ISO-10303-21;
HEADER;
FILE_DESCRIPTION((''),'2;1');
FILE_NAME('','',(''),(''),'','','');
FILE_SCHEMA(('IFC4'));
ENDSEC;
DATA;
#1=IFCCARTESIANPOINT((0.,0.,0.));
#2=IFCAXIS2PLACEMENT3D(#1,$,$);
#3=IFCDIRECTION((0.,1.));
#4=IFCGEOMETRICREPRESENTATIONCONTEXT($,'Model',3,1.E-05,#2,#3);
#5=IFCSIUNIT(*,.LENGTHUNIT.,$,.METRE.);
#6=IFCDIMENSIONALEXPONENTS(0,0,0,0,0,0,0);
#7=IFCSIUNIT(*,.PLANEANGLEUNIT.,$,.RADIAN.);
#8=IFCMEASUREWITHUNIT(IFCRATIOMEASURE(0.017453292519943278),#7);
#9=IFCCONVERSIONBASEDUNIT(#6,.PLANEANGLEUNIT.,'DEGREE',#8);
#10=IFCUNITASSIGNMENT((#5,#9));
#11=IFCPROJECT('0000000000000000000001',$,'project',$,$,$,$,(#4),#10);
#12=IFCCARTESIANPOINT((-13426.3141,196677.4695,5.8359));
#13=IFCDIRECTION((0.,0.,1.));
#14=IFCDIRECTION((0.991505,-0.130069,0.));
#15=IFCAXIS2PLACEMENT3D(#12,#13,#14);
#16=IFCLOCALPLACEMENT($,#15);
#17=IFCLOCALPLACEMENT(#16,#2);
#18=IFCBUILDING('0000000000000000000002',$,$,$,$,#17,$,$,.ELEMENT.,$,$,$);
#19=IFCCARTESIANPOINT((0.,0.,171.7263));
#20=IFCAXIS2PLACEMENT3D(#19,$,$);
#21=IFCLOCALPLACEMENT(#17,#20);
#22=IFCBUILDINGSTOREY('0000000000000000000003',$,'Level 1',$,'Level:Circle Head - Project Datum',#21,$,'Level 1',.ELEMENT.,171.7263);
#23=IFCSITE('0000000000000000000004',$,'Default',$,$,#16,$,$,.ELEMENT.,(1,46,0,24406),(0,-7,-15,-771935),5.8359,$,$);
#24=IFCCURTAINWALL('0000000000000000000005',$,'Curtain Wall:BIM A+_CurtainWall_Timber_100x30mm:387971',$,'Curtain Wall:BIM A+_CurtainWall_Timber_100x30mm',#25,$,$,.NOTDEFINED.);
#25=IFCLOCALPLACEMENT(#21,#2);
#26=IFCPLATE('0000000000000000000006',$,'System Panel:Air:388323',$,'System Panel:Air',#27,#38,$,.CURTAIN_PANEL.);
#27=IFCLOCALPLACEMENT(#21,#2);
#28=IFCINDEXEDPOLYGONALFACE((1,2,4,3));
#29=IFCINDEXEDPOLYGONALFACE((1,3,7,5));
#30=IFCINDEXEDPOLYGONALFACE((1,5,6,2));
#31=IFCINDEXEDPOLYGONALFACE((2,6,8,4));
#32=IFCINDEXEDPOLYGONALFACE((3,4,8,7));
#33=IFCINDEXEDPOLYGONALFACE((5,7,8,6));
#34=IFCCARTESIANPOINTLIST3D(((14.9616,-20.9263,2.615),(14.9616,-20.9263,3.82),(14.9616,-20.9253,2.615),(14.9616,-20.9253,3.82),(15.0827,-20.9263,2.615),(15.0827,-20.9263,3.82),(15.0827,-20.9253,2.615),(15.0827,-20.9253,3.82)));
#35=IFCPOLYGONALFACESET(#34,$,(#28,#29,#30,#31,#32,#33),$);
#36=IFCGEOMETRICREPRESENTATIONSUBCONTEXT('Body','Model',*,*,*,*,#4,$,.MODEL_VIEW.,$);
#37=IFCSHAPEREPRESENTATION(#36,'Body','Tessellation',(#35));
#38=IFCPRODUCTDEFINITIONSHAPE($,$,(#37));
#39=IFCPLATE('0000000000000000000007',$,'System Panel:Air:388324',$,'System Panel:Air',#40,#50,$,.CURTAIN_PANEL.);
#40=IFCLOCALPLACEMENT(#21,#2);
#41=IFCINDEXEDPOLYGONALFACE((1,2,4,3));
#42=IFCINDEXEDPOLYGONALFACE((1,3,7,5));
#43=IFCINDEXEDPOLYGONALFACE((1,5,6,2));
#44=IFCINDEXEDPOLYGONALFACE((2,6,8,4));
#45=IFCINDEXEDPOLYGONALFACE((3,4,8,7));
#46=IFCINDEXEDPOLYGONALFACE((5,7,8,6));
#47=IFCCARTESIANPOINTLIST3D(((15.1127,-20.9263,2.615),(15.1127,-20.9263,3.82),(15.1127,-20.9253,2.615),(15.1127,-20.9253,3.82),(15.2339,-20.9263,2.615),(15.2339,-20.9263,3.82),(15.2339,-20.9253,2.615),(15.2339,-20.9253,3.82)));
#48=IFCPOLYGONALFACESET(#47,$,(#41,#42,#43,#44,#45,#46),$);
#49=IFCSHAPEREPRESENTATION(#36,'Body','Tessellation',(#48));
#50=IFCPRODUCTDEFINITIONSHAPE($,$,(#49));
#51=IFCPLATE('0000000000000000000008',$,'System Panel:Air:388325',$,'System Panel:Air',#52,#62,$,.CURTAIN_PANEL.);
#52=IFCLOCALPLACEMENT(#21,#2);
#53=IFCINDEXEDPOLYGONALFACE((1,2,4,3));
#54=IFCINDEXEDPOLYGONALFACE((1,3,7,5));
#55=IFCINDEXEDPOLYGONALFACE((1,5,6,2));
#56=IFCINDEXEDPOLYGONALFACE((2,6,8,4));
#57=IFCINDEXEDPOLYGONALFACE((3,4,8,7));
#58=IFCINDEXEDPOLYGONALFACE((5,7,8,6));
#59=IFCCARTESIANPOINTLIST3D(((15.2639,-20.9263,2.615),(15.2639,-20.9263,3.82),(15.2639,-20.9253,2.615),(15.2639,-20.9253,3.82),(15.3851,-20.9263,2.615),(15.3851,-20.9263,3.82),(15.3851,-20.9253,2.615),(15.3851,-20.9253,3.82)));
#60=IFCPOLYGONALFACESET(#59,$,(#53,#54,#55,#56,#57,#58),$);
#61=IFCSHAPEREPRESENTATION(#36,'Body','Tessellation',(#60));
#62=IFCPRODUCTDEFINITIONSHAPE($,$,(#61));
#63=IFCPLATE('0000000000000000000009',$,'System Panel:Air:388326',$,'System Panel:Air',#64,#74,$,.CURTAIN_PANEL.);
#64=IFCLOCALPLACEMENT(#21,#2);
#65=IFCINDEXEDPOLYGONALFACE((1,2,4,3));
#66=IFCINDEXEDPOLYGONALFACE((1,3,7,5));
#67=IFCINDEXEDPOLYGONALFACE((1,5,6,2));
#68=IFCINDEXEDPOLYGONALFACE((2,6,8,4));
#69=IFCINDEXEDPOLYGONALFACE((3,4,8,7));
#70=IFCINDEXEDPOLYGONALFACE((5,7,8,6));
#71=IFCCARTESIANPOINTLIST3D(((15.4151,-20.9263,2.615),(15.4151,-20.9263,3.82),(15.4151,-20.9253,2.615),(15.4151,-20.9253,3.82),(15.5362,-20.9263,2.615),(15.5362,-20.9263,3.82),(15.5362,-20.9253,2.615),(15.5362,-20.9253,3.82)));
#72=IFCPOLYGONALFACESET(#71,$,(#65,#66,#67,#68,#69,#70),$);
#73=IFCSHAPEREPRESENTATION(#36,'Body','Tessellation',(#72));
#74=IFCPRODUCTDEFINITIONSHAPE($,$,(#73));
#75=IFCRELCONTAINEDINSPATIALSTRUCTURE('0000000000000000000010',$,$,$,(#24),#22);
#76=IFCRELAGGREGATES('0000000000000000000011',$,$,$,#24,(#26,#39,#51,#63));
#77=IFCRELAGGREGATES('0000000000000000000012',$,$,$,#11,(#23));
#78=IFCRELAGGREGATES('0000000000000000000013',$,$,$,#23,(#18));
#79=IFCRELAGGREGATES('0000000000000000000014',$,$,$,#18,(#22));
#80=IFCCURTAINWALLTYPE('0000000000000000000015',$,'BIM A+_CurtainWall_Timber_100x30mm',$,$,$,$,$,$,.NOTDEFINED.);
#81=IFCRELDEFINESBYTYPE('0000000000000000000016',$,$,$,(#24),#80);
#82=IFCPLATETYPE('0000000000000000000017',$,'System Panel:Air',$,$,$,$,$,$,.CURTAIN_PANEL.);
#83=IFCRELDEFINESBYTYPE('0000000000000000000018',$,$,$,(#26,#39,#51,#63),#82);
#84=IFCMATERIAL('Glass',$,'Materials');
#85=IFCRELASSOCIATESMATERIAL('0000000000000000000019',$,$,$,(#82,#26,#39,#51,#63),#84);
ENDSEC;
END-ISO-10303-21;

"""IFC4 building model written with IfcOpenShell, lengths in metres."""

from ifc_helpers import new_model, entity, si_unit, converted_unit, direction, frame, origin, place, context, subcontext, project, spatial, indexed_curve, outline, extrude, source, transform, mapped, material, type_object, type_shapes, element, aggregate, save


model = new_model("IFC4")

# Units and contexts
model_context = context("Model", 3, precision=1e-05, world=origin(), true_north=direction((0.0, 1.0)))
body_context = subcontext(model_context, "Body", "Model", "MODEL_VIEW")
ifc_project = project(units=[si_unit("LENGTHUNIT", "METRE"), converted_unit("PLANEANGLEUNIT", "DEGREE", entity("IfcRatioMeasure", 0.017453292519943278), si_unit("PLANEANGLEUNIT", "RADIAN"), dimensions=[0, 0, 0, 0, 0, 0, 0])], contexts=[model_context])

# Site, building, storey
site_placement = place(None, frame((-13426.3141, 196677.4695, 5.8359), z_axis=(0.0, 0.0, 1.0), x_axis=(0.991505, -0.130069, 0.0)))
site = spatial("IfcSite", under=ifc_project, at=site_placement, Name="Default", CompositionType="ELEMENT", RefLatitude=(1, 46, 0, 24406), RefLongitude=(0, -7, -15, -771935), RefElevation=5.8359)
building_placement = place(site_placement, origin())
building = spatial("IfcBuilding", under=site, at=building_placement, CompositionType="ELEMENT")
storey_placement = place(building_placement, frame((0.0, 0.0, 171.7263)))
storey = spatial("IfcBuildingStorey", under=building, at=storey_placement, Name="Level 1", ObjectType="Level:Circle Head - Project Datum", LongName="Level 1", CompositionType="ELEMENT", Elevation=171.7263)

# Curtain wall
curtain_wall_type_1 = type_object("IfcCurtainWallType", Name="BIM A+_CurtainWall_Timber_100x30mm", PredefinedType="NOTDEFINED")
curtain_wall_1_placement = place(storey_placement, frame((0.0, 0.0, -171.7263)))
curtain_wall_1 = element("IfcCurtainWall", 1, at=curtain_wall_1_placement, inside=storey, type_object=curtain_wall_type_1, Name="Curtain Wall:BIM A+_CurtainWall_Timber_100x30mm:387971", ObjectType="Curtain Wall:BIM A+_CurtainWall_Timber_100x30mm", PredefinedType="NOTDEFINED")

# Plates
ifc_material_1 = material(Name="Glass", Category="Materials")
plate_type_1 = type_object("IfcPlateType", Name="System Panel:Air", PredefinedType="CURTAIN_PANEL", material=ifc_material_1)
shared_shape_1 = source(origin(), body_context, "Body", "SweptSolid", [
    extrude(outline(indexed_curve([(-0.0005, -0.0606), (0.0005, -0.0606), (0.0005, 0.0606), (-0.0005, 0.0606), (-0.0005, -0.0606)], self_intersect=False)), frame((0.0, 0.0, 0.0), z_axis=(0.0, 0.0, 1.0), x_axis=(0.0, 1.0, 0.0)), (0.0, 0.0, 1.0), 1.205),
])
type_shapes(plate_type_1, [shared_shape_1])
plate_1_placement = place(curtain_wall_1_placement, frame((15.0222, -20.9258, 174.3413)))
plate_1 = element("IfcPlate", 2, at=plate_1_placement, type_object=plate_type_1, material=ifc_material_1, Name="System Panel:Air:388323", ObjectType="System Panel:Air", PredefinedType="CURTAIN_PANEL", context=body_context, shape_type="MappedRepresentation", body=[
    mapped(shared_shape_1, transform((0.0, 0.0, 0.0), scale=1.0)),
])
plate_2_placement = place(curtain_wall_1_placement, frame((15.1733, -20.9258, 174.3413)))
plate_2 = element("IfcPlate", 3, at=plate_2_placement, type_object=plate_type_1, material=ifc_material_1, Name="System Panel:Air:388324", ObjectType="System Panel:Air", PredefinedType="CURTAIN_PANEL", context=body_context, shape_type="MappedRepresentation", body=[
    mapped(shared_shape_1, transform((0.0, 0.0, 0.0), scale=1.0)),
])
plate_3_placement = place(curtain_wall_1_placement, frame((15.3245, -20.9258, 174.3413)))
plate_3 = element("IfcPlate", 4, at=plate_3_placement, type_object=plate_type_1, material=ifc_material_1, Name="System Panel:Air:388325", ObjectType="System Panel:Air", PredefinedType="CURTAIN_PANEL", context=body_context, shape_type="MappedRepresentation", body=[
    mapped(shared_shape_1, transform((0.0, 0.0, 0.0), scale=1.0)),
])
plate_4_placement = place(curtain_wall_1_placement, frame((15.4757, -20.9258, 174.3413)))
plate_4 = element("IfcPlate", 5, at=plate_4_placement, type_object=plate_type_1, material=ifc_material_1, Name="System Panel:Air:388326", ObjectType="System Panel:Air", PredefinedType="CURTAIN_PANEL", context=body_context, shape_type="MappedRepresentation", body=[
    mapped(shared_shape_1, transform((0.0, 0.0, 0.0), scale=1.0)),
])
aggregate(curtain_wall_1, [plate_1, plate_2, plate_3, plate_4])

save(model, "model.ifc")
